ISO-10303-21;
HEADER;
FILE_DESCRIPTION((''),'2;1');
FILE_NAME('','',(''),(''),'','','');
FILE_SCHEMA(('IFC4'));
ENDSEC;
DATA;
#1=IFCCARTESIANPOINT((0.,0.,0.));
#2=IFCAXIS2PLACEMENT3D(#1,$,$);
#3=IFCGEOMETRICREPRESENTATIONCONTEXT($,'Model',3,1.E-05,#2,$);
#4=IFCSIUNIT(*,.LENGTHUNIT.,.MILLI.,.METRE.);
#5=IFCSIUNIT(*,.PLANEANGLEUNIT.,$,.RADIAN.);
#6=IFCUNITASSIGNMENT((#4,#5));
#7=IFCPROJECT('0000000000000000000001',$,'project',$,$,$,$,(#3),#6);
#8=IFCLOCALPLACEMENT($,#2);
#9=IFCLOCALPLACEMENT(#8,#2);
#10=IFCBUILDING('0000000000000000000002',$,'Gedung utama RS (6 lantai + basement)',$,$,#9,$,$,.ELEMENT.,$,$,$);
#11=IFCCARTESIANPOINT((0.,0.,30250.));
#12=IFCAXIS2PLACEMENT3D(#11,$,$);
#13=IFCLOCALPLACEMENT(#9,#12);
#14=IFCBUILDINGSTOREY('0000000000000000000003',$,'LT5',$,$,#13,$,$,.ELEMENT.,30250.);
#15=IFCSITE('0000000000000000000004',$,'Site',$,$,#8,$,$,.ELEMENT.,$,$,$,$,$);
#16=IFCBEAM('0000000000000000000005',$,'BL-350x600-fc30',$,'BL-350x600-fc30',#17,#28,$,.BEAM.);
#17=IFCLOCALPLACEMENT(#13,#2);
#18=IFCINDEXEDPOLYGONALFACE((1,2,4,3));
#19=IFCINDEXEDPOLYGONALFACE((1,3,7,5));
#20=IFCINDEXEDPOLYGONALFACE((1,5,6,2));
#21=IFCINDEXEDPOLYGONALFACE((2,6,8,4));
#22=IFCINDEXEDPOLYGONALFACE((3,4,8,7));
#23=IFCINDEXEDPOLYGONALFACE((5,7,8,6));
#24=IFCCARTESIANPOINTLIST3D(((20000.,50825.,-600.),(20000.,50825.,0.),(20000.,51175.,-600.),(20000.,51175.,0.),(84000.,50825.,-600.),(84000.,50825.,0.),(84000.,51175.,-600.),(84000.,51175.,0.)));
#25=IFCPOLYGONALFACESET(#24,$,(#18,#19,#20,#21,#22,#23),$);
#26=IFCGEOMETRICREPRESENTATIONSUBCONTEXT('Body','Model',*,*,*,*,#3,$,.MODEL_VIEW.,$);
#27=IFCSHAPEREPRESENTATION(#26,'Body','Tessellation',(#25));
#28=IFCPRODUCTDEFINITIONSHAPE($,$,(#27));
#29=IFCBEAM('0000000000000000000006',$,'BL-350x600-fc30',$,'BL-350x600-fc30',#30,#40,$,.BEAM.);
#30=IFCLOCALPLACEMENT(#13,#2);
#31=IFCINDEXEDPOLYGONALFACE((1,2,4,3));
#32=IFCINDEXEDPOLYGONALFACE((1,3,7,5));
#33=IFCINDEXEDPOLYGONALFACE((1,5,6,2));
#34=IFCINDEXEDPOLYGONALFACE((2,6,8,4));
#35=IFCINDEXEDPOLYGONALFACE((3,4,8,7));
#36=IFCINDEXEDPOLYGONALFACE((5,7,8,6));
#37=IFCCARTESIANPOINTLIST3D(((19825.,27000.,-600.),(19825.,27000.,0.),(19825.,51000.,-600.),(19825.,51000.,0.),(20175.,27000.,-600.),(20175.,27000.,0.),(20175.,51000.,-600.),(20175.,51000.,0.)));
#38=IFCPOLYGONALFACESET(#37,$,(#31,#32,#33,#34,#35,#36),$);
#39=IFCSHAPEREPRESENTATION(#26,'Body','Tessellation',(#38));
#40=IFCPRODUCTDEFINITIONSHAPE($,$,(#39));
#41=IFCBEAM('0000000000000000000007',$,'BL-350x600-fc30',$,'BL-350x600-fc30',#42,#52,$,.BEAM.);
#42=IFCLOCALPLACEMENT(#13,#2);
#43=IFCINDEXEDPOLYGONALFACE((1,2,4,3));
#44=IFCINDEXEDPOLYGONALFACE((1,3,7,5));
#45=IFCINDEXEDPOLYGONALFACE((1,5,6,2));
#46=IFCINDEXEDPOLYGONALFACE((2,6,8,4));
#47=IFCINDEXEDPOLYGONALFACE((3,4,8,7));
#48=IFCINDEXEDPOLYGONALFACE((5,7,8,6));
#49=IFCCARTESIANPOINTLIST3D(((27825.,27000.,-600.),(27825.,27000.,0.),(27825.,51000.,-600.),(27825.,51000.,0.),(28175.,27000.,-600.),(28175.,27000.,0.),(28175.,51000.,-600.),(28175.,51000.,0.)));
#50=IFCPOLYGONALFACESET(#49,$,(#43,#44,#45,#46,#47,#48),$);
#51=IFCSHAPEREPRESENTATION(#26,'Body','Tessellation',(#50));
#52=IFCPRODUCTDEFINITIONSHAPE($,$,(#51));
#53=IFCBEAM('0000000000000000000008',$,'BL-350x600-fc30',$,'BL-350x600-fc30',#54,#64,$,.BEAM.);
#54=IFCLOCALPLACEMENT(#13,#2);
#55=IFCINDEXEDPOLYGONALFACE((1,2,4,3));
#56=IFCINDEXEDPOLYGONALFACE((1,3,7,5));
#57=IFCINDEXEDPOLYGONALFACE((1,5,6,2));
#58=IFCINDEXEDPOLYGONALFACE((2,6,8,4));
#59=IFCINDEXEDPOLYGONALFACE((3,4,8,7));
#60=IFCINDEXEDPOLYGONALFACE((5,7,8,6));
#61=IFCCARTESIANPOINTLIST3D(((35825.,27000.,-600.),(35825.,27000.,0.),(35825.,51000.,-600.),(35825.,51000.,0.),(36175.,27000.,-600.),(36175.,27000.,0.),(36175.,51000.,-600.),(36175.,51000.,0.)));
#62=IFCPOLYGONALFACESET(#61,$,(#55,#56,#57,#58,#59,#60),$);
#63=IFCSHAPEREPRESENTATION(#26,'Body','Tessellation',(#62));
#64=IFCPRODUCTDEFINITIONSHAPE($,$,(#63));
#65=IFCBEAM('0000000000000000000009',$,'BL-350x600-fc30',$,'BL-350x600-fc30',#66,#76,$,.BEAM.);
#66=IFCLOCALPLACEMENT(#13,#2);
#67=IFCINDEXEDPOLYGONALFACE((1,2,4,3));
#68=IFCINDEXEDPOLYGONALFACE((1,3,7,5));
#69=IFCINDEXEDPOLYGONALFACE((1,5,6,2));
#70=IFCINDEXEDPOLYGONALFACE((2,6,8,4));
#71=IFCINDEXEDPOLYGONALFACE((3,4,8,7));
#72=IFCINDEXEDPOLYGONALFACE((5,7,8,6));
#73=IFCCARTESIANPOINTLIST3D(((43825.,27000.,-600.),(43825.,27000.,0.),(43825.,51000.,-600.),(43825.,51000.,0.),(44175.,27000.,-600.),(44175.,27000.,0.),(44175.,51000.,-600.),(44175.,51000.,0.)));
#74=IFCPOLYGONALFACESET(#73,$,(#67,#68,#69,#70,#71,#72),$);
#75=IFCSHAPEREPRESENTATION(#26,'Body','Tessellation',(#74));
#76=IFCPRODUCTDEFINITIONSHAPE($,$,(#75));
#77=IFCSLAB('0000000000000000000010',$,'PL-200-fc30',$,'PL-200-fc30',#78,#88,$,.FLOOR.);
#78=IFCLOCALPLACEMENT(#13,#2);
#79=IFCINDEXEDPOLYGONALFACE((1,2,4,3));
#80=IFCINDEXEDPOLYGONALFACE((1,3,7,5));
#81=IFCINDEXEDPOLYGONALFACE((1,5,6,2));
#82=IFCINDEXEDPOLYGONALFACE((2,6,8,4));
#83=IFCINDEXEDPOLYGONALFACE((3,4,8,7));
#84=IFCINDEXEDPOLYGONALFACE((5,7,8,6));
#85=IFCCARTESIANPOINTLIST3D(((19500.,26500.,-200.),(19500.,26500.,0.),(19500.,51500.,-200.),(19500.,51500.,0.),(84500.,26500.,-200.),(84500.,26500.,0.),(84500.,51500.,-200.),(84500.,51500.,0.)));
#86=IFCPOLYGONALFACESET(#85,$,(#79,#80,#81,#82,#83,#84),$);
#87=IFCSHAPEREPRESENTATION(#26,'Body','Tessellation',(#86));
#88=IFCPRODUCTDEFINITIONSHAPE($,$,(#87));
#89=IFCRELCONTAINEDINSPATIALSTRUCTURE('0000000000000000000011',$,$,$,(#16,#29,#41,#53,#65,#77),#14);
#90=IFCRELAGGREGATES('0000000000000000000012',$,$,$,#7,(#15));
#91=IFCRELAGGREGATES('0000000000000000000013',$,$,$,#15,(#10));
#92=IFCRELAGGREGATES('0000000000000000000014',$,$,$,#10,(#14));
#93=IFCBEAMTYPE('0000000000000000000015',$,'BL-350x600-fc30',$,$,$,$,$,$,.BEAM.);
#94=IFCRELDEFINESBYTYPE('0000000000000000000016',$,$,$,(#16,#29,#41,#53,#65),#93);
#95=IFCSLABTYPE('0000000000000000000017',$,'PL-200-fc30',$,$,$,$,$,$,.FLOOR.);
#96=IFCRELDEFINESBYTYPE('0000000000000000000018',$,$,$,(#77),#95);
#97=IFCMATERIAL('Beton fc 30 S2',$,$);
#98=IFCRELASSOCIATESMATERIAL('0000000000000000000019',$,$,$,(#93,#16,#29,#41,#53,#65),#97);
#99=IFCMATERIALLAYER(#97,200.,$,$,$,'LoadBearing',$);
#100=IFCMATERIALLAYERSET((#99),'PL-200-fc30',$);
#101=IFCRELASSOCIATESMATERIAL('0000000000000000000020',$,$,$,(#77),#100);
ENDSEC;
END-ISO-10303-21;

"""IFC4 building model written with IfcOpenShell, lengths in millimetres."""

from ifc_helpers import new_model, si_unit, frame, origin, origin_2d, place, context, subcontext, project, spatial, polyline, rectangle, outline, extrude, material, layer, layer_set, layer_usage, material_profile, profile_set, profile_usage, type_object, element, save


model = new_model("IFC4")

# Units and contexts
model_context = context("Model", 3, precision=1e-05, world=origin())
body_context = subcontext(model_context, "Body", "Model", "MODEL_VIEW")
ifc_project = project(units=[si_unit("LENGTHUNIT", "METRE", prefix="MILLI"), si_unit("PLANEANGLEUNIT", "RADIAN")], contexts=[model_context])

# Site, building, storey
site_placement = place(None, origin())
site = spatial("IfcSite", under=ifc_project, at=site_placement, Name="Site", CompositionType="ELEMENT")
building_placement = place(site_placement, origin())
building = spatial("IfcBuilding", under=site, at=building_placement, Name="Gedung utama RS (6 lantai + basement)", CompositionType="ELEMENT")
storey_placement = place(building_placement, frame((0.0, 0.0, 30250.0)))
storey = spatial("IfcBuildingStorey", under=building, at=storey_placement, Name="LT5", CompositionType="ELEMENT", Elevation=30250.0)

# Beams
ifc_material = material(Name="Beton fc 30 S2")
ifc_material_profile_1 = material_profile(ifc_material, rectangle(XDim=350.0, YDim=600.0, at=origin_2d()), Name="BL-350x600-fc30")
ifc_profile_set_1 = profile_set([ifc_material_profile_1], Name="BL-350x600-fc30")
ifc_profile_usage_1 = profile_usage(ifc_profile_set_1, cardinal=8)
beam_type = type_object("IfcBeamType", Name="BL-350x600-fc30", PredefinedType="BEAM", material=ifc_profile_set_1)
for number, where, name in (
    (1, (20000.0, 51000.0, -300.0), "BL-350x600-fc30"),
):
    element("IfcBeam", number, at=place(storey_placement, frame(where)), inside=storey, type_object=beam_type, material=ifc_profile_usage_1, Name=name, ObjectType="BL-350x600-fc30", PredefinedType="BEAM", context=body_context, shape_type="SweptSolid", body=[
        extrude(rectangle(XDim=350.0, YDim=600.0, at=origin_2d()), frame((0.0, 0.0, 0.0), z_axis=(1.0, 0.0, 0.0), x_axis=(0.0, 1.0, 0.0)), (0.0, 0.0, 1.0), 64000.0),
    ])
for number, where, name in (
    (2, (20000.0, 27000.0, -300.0), "BL-350x600-fc30"),
    (3, (28000.0, 27000.0, -300.0), "BL-350x600-fc30"),
    (4, (36000.0, 27000.0, -300.0), "BL-350x600-fc30"),
    (5, (44000.0, 27000.0, -300.0), "BL-350x600-fc30"),
):
    element("IfcBeam", number, at=place(storey_placement, frame(where)), inside=storey, type_object=beam_type, material=ifc_profile_usage_1, Name=name, ObjectType="BL-350x600-fc30", PredefinedType="BEAM", context=body_context, shape_type="SweptSolid", body=[
        extrude(rectangle(XDim=350.0, YDim=600.0, at=origin_2d()), frame((0.0, 0.0, 0.0), z_axis=(0.0, 1.0, 0.0), x_axis=(-1.0, 0.0, 0.0)), (0.0, 0.0, 1.0), 24000.0),
    ])

# Slab
ifc_layer = layer(ifc_material, 200.0, Category="LoadBearing")
ifc_layer_set = layer_set([ifc_layer], Name="PL-200-fc30")
ifc_layer_usage = layer_usage(ifc_layer_set, "AXIS3", "NEGATIVE", 0.0)
slab_type = type_object("IfcSlabType", Name="PL-200-fc30", PredefinedType="FLOOR")
slab_placement = place(storey_placement, origin())
element("IfcSlab", 6, at=slab_placement, inside=storey, type_object=slab_type, material=ifc_layer_usage, Name="PL-200-fc30", ObjectType="PL-200-fc30", PredefinedType="FLOOR", context=body_context, shape_type="SweptSolid", body=[
    extrude(outline(polyline([(19500.0, 26500.0), (84500.0, 26500.0), (84500.0, 51500.0), (19500.0, 51500.0), (19500.0, 26500.0)])), frame((0.0, 0.0, -200.0)), (0.0, 0.0, 1.0), 200.0),
])

save(model, "model.ifc")
